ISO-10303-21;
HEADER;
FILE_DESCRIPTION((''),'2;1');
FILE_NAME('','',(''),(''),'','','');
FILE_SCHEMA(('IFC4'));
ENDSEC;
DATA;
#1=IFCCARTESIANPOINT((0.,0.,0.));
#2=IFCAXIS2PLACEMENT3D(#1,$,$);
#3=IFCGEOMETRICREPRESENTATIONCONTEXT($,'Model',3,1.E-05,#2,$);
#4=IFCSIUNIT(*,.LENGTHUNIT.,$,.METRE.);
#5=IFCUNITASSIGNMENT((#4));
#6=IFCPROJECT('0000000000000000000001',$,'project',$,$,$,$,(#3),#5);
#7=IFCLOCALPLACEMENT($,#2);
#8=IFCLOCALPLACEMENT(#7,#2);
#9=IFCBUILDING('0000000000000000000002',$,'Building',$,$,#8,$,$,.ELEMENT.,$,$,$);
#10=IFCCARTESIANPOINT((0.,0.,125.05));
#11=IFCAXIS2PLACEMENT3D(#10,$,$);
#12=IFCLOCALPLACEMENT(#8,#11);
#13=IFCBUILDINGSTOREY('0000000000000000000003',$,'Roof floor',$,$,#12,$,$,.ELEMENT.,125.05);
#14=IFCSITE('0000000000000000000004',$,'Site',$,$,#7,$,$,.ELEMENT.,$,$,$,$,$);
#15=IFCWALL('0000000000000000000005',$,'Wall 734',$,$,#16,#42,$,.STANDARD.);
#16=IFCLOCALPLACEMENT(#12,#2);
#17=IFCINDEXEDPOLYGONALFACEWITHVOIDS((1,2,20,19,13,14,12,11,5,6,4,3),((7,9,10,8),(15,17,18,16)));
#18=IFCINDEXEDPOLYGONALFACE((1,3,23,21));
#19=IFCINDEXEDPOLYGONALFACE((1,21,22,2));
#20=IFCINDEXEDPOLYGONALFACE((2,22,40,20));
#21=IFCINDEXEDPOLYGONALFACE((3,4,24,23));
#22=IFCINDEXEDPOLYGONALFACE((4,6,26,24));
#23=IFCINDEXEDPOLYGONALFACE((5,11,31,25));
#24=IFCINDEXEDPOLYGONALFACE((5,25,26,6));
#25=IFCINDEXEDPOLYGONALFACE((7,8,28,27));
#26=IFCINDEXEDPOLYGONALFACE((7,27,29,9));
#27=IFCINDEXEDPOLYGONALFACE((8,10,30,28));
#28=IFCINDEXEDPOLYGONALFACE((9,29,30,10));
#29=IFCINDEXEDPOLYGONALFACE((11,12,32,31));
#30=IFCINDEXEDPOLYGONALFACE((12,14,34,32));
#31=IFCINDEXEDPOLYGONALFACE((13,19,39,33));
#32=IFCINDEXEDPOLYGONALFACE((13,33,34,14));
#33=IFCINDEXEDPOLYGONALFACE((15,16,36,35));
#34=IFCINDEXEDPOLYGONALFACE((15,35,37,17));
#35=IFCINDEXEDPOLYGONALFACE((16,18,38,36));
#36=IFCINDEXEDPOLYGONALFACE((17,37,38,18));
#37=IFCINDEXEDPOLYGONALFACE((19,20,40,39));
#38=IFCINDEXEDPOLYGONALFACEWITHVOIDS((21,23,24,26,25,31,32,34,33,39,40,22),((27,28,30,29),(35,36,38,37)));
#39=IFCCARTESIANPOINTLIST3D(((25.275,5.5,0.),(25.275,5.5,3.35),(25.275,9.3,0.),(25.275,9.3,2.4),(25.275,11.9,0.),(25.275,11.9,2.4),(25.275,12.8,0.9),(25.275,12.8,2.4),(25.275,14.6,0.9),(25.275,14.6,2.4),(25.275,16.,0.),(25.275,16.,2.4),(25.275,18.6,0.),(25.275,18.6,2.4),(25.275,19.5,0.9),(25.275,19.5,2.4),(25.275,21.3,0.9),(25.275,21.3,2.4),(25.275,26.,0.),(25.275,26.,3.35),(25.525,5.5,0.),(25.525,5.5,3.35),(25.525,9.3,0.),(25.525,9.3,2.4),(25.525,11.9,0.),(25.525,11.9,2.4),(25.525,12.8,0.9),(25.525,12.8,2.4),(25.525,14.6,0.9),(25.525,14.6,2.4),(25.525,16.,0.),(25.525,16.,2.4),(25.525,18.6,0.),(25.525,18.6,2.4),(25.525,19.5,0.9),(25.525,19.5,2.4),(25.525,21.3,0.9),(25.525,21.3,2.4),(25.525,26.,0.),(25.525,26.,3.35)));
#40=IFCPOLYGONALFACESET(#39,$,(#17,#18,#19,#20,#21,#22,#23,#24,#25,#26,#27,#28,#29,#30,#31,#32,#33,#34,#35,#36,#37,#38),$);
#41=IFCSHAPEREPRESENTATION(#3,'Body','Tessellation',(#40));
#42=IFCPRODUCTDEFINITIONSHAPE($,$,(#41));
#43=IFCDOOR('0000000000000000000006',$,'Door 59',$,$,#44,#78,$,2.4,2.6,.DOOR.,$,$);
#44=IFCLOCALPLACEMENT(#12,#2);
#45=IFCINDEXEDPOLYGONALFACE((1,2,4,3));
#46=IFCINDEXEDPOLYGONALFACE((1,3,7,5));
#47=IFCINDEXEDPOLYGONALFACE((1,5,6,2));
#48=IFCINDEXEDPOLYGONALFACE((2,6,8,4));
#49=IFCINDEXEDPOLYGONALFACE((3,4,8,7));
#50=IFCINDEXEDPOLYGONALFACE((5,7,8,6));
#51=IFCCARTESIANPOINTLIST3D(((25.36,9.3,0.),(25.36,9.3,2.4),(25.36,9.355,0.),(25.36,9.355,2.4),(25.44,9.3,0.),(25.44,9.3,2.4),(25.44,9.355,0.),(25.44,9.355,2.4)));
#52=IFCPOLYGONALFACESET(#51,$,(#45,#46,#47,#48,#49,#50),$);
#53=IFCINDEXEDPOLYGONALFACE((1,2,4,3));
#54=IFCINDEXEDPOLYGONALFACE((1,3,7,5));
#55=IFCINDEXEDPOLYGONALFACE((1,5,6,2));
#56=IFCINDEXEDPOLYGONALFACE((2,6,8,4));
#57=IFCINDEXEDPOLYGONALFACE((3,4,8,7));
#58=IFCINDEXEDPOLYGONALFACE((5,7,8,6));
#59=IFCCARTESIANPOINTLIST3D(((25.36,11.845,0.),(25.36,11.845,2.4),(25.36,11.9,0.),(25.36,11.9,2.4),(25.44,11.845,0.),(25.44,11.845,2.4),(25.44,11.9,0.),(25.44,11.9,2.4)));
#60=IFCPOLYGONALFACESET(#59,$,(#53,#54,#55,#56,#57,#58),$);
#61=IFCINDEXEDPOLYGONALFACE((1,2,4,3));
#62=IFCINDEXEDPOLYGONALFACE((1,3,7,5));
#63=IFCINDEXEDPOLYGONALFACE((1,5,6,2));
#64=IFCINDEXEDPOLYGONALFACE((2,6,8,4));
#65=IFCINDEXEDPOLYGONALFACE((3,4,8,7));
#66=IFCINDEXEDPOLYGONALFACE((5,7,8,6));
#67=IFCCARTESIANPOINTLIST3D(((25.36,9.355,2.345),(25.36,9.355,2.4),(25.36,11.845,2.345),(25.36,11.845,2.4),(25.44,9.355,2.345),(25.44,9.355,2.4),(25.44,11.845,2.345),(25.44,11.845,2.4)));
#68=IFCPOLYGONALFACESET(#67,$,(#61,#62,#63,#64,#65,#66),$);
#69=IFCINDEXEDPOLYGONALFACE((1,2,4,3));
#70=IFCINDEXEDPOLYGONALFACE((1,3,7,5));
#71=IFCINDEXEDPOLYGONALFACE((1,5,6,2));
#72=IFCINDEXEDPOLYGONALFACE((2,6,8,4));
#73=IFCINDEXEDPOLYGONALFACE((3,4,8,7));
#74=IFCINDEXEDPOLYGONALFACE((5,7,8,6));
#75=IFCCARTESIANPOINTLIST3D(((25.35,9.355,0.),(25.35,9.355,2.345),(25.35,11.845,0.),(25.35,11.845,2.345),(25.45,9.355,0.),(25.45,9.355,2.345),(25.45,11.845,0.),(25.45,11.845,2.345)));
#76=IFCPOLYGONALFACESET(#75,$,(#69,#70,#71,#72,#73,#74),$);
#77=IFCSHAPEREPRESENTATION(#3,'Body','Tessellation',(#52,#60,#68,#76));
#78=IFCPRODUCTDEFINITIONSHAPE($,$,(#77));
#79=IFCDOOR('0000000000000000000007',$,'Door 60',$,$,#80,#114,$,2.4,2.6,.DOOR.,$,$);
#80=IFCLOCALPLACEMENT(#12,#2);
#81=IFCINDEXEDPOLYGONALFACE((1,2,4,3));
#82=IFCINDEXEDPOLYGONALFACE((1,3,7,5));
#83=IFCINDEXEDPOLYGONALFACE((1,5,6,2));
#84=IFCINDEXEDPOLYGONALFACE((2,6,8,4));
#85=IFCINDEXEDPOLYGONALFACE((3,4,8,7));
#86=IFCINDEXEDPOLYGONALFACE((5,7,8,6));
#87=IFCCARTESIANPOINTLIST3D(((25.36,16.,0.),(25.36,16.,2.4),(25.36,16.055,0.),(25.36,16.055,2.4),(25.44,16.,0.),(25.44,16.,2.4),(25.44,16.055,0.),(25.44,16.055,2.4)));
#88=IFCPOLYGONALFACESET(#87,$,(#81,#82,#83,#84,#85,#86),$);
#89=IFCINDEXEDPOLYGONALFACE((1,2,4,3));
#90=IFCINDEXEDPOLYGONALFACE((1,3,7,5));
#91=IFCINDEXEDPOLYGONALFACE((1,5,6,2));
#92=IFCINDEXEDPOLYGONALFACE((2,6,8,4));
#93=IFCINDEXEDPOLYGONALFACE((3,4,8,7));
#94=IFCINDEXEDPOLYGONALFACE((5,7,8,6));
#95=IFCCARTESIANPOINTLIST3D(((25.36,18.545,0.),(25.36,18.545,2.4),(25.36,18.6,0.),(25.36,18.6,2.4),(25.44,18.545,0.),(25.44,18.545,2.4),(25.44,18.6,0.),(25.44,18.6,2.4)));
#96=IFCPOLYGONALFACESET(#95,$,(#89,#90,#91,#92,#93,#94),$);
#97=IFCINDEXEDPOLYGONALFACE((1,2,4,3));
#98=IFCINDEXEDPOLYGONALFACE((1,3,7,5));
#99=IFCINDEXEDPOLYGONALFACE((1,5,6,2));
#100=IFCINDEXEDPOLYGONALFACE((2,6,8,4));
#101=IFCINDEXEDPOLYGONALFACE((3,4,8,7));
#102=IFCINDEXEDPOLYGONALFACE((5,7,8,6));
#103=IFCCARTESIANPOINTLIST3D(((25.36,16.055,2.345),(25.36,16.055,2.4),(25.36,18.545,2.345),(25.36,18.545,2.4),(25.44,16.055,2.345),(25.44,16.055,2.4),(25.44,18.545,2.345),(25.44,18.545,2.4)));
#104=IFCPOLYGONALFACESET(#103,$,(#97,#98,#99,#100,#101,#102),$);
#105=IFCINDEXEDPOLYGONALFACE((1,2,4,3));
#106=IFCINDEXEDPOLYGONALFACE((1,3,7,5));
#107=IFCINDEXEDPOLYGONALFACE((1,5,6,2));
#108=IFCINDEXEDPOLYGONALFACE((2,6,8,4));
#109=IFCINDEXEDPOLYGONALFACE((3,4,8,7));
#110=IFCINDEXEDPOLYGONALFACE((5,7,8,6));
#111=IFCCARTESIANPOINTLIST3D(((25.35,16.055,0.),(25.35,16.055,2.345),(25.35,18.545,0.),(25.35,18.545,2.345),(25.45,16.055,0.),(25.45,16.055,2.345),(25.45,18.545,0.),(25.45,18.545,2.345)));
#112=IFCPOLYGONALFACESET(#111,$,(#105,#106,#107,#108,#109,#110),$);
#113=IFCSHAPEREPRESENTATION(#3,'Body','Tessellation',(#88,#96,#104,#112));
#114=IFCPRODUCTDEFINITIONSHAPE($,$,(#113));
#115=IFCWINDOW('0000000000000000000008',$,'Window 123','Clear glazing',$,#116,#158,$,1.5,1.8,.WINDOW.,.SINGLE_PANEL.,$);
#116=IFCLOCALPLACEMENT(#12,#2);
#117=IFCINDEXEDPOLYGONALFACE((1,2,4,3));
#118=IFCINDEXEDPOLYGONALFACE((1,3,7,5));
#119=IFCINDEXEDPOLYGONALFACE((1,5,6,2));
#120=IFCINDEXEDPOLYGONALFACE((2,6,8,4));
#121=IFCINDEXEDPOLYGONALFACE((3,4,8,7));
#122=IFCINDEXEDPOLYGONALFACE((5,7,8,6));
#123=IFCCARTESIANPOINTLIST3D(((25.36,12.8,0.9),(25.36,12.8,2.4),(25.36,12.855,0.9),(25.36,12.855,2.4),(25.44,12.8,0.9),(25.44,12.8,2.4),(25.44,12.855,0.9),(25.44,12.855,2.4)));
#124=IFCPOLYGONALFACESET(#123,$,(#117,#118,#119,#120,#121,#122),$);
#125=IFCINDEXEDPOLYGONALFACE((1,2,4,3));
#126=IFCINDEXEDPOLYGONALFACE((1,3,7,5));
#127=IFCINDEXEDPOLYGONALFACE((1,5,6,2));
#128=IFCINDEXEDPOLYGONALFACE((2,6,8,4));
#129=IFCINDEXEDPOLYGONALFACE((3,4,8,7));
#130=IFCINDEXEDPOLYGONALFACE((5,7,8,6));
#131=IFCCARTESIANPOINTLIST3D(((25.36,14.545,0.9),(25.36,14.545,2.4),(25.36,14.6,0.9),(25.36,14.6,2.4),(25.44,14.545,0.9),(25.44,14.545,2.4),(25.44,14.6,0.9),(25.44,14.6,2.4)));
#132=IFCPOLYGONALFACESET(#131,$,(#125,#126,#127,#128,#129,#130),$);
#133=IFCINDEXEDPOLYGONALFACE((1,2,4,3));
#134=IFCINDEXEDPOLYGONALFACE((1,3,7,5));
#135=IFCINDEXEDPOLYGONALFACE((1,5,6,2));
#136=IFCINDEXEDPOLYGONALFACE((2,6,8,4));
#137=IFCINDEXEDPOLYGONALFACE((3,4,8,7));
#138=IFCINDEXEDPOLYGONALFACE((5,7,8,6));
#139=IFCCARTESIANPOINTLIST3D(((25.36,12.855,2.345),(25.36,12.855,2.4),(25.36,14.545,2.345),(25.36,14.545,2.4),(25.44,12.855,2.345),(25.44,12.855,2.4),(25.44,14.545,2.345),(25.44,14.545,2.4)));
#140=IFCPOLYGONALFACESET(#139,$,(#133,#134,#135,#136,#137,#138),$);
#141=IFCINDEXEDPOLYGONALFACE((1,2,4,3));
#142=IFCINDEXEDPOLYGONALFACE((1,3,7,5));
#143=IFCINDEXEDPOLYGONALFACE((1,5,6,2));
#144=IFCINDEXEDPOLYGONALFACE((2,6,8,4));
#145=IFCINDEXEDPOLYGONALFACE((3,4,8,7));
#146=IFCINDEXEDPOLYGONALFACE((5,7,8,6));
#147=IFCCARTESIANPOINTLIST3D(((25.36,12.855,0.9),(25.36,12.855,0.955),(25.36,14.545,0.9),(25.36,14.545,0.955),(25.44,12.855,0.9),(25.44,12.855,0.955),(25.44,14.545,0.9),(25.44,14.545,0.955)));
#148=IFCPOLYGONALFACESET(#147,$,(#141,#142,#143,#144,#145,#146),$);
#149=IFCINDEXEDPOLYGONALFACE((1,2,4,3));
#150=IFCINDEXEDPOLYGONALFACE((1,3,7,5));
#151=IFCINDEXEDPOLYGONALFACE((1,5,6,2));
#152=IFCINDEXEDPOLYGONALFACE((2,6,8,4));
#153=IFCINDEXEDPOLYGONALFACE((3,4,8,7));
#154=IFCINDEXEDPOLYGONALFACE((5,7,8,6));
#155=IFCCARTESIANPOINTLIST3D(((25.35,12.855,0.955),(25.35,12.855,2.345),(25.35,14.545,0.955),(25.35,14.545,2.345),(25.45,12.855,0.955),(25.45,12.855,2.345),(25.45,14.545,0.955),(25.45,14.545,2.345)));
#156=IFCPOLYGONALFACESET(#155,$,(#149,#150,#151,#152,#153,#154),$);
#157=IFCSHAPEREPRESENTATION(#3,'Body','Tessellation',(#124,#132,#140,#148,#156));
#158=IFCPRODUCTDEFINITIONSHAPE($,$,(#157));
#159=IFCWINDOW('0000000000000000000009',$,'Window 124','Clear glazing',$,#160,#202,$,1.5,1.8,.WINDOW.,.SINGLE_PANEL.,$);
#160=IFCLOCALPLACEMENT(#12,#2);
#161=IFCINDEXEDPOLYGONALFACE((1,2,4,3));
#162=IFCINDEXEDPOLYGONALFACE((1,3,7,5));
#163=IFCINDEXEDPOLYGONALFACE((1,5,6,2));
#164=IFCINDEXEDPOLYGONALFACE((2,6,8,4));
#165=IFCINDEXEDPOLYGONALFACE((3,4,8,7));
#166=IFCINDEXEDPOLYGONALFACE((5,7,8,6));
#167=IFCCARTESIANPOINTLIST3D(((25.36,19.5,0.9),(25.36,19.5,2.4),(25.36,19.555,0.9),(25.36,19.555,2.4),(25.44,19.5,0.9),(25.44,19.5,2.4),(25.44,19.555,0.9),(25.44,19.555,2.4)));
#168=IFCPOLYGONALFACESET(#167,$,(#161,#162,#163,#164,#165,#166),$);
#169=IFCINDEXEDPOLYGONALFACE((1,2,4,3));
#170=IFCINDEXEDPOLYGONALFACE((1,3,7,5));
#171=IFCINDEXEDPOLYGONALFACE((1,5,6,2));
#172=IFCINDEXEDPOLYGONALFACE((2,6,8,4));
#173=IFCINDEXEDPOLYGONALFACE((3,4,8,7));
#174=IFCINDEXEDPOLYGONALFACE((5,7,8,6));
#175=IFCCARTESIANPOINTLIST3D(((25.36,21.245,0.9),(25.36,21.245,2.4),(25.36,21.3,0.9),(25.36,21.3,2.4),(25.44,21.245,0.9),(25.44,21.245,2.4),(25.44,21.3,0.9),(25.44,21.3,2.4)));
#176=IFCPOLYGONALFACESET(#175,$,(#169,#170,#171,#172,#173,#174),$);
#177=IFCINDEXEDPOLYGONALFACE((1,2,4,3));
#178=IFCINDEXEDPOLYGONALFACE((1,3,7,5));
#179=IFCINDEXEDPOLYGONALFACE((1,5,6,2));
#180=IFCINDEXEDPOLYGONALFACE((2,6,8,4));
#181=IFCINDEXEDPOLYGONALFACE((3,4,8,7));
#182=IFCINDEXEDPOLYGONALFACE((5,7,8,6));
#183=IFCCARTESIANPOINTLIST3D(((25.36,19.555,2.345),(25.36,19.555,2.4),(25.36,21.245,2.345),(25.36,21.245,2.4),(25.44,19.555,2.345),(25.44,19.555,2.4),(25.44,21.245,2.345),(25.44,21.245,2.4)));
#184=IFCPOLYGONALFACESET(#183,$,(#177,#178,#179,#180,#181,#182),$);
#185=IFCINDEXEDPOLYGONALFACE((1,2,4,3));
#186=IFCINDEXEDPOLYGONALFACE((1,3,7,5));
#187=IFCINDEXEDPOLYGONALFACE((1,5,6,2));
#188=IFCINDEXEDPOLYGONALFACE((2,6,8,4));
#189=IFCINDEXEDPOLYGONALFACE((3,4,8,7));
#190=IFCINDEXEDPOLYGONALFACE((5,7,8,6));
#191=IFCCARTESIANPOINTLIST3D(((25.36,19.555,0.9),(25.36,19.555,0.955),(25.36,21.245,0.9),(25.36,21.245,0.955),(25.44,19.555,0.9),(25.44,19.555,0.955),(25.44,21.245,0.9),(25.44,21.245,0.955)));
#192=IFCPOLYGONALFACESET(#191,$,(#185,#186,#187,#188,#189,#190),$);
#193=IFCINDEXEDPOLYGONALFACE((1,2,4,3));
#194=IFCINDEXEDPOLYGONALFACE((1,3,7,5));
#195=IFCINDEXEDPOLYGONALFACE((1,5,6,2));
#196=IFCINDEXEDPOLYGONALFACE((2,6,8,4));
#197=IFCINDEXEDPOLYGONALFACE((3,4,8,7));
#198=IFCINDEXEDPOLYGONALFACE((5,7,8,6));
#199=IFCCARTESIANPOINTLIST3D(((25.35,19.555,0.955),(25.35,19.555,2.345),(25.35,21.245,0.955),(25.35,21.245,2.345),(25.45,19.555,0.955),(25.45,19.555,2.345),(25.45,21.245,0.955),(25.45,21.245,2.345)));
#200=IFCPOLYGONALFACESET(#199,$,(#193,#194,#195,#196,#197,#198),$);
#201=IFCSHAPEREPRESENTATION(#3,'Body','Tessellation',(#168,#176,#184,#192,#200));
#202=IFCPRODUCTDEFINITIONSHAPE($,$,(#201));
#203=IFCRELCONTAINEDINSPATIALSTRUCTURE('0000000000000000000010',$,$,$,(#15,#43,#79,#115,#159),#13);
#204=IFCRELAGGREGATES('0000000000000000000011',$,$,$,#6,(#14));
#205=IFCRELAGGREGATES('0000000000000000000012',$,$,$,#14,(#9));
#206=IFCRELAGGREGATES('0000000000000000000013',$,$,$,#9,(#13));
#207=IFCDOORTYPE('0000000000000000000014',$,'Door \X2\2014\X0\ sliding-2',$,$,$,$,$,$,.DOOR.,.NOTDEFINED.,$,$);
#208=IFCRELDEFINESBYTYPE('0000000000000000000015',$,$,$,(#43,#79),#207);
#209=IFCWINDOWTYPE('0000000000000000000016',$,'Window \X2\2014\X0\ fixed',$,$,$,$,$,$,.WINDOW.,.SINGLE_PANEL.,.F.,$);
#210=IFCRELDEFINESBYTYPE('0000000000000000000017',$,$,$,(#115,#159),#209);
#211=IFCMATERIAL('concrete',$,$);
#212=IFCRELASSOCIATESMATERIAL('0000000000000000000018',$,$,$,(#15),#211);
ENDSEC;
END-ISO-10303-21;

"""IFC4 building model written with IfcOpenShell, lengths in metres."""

from ifc_helpers import new_model, si_unit, frame, frame_2d, origin, place, context, project, spatial, rectangle, extrude, material, type_object, element, fill, save


model = new_model("IFC4")

# Units and contexts
model_context = context("Model", 3, precision=1e-05, world=origin())
ifc_project = project(units=[si_unit("LENGTHUNIT", "METRE")], contexts=[model_context])

# Site, building, storey
site_placement = place(None, origin())
site = spatial("IfcSite", under=ifc_project, at=site_placement, Name="Site", CompositionType="ELEMENT")
building_placement = place(site_placement, origin())
building = spatial("IfcBuilding", under=site, at=building_placement, Name="Building", CompositionType="ELEMENT")
storey_placement = place(building_placement, frame((0.0, 0.0, 125.05)))
storey = spatial("IfcBuildingStorey", under=building, at=storey_placement, Name="Roof floor", CompositionType="ELEMENT", Elevation=125.05)

# Shared definitions
ifc_material = material(Name="concrete")

# Shared definitions
door_type = type_object("IfcDoorType", Name="Door — sliding-2", PredefinedType="DOOR")
window_type = type_object("IfcWindowType", Name="Window — fixed", ParameterTakesPrecedence=False, PartitioningType="SINGLE_PANEL", PredefinedType="WINDOW")

# Wall, openings, doors, windows
wall_1_placement = place(storey_placement, frame((25.4, 5.5, 0.0), z_axis=(0.0, 0.0, 1.0), x_axis=(0.0, 1.0, 0.0)))
wall_1 = element("IfcWall", 1, at=wall_1_placement, inside=storey, material=ifc_material, Name="Wall 734", PredefinedType="STANDARD", context=model_context, shape_type="SweptSolid", body=[
    extrude(rectangle(XDim=20.5, YDim=0.25, at=frame_2d((10.25, 0.0))), origin(), (0.0, 0.0, 1.0), 3.35),
])
opening_1_placement = place(storey_placement, frame((25.4, 9.3, 0.0), z_axis=(0.0, 0.0, 1.0), x_axis=(0.0, 1.0, 0.0)))
opening_1 = element("IfcOpeningElement", 2, at=opening_1_placement, cuts=wall_1, PredefinedType="OPENING", context=model_context, shape_type="SweptSolid", body=[
    extrude(rectangle(XDim=2.6, YDim=0.31, at=frame_2d((1.3, 0.0))), origin(), (0.0, 0.0, 1.0), 2.4),
])
opening_2_placement = place(storey_placement, frame((25.4, 12.8, 0.9), z_axis=(0.0, 0.0, 1.0), x_axis=(0.0, 1.0, 0.0)))
opening_2 = element("IfcOpeningElement", 3, at=opening_2_placement, cuts=wall_1, PredefinedType="OPENING", context=model_context, shape_type="SweptSolid", body=[
    extrude(rectangle(XDim=1.8, YDim=0.31, at=frame_2d((0.9, 0.0))), origin(), (0.0, 0.0, 1.0), 1.5),
])
opening_3_placement = place(storey_placement, frame((25.4, 16.0, 0.0), z_axis=(0.0, 0.0, 1.0), x_axis=(0.0, 1.0, 0.0)))
opening_3 = element("IfcOpeningElement", 4, at=opening_3_placement, cuts=wall_1, PredefinedType="OPENING", context=model_context, shape_type="SweptSolid", body=[
    extrude(rectangle(XDim=2.6, YDim=0.31, at=frame_2d((1.3, 0.0))), origin(), (0.0, 0.0, 1.0), 2.4),
])
opening_4_placement = place(storey_placement, frame((25.4, 19.5, 0.9), z_axis=(0.0, 0.0, 1.0), x_axis=(0.0, 1.0, 0.0)))
opening_4 = element("IfcOpeningElement", 5, at=opening_4_placement, cuts=wall_1, PredefinedType="OPENING", context=model_context, shape_type="SweptSolid", body=[
    extrude(rectangle(XDim=1.8, YDim=0.31, at=frame_2d((0.9, 0.0))), origin(), (0.0, 0.0, 1.0), 1.5),
])
door_1_placement = place(storey_placement, frame((25.4, 9.3, 0.0), z_axis=(0.0, 0.0, 1.0), x_axis=(0.0, 1.0, 0.0)))
door_1 = element("IfcDoor", 6, at=door_1_placement, inside=storey, type_object=door_type, Name="Door 59", OverallHeight=2.4, OverallWidth=2.6, PredefinedType="DOOR", context=model_context, shape_type="SweptSolid", body=[
    extrude(rectangle(XDim=0.055, YDim=0.08, at=frame_2d((0.0275, 0.0))), origin(), (0.0, 0.0, 1.0), 2.4),
    extrude(rectangle(XDim=0.055, YDim=0.08, at=frame_2d((2.5725, 0.0))), origin(), (0.0, 0.0, 1.0), 2.4),
    extrude(rectangle(XDim=2.49, YDim=0.08, at=frame_2d((1.3, 0.0))), frame((0.0, 0.0, 2.345)), (0.0, 0.0, 1.0), 0.055),
    extrude(rectangle(XDim=2.49, YDim=0.1, at=frame_2d((1.3, 0.0))), origin(), (0.0, 0.0, 1.0), 2.345),
])
fill(opening_1, door_1)
door_2_placement = place(storey_placement, frame((25.4, 16.0, 0.0), z_axis=(0.0, 0.0, 1.0), x_axis=(0.0, 1.0, 0.0)))
door_2 = element("IfcDoor", 7, at=door_2_placement, inside=storey, type_object=door_type, Name="Door 60", OverallHeight=2.4, OverallWidth=2.6, PredefinedType="DOOR", context=model_context, shape_type="SweptSolid", body=[
    extrude(rectangle(XDim=0.055, YDim=0.08, at=frame_2d((0.0275, 0.0))), origin(), (0.0, 0.0, 1.0), 2.4),
    extrude(rectangle(XDim=0.055, YDim=0.08, at=frame_2d((2.5725, 0.0))), origin(), (0.0, 0.0, 1.0), 2.4),
    extrude(rectangle(XDim=2.49, YDim=0.08, at=frame_2d((1.3, 0.0))), frame((0.0, 0.0, 2.345)), (0.0, 0.0, 1.0), 0.055),
    extrude(rectangle(XDim=2.49, YDim=0.1, at=frame_2d((1.3, 0.0))), origin(), (0.0, 0.0, 1.0), 2.345),
])
fill(opening_3, door_2)
window_1_placement = place(storey_placement, frame((25.4, 12.8, 0.9), z_axis=(0.0, 0.0, 1.0), x_axis=(0.0, 1.0, 0.0)))
window_1 = element("IfcWindow", 8, at=window_1_placement, inside=storey, type_object=window_type, Name="Window 123", Description="Clear glazing", OverallHeight=1.5, OverallWidth=1.8, PartitioningType="SINGLE_PANEL", PredefinedType="WINDOW", context=model_context, shape_type="SweptSolid", body=[
    extrude(rectangle(XDim=0.055, YDim=0.08, at=frame_2d((0.0275, 0.0))), origin(), (0.0, 0.0, 1.0), 1.5),
    extrude(rectangle(XDim=0.055, YDim=0.08, at=frame_2d((1.7725, 0.0))), origin(), (0.0, 0.0, 1.0), 1.5),
    extrude(rectangle(XDim=1.69, YDim=0.08, at=frame_2d((0.9, 0.0))), frame((0.0, 0.0, 1.445)), (0.0, 0.0, 1.0), 0.055),
    extrude(rectangle(XDim=1.69, YDim=0.08, at=frame_2d((0.9, 0.0))), origin(), (0.0, 0.0, 1.0), 0.055),
    extrude(rectangle(XDim=1.69, YDim=0.1, at=frame_2d((0.9, 0.0))), frame((0.0, 0.0, 0.055)), (0.0, 0.0, 1.0), 1.39),
])
fill(opening_2, window_1)
window_2_placement = place(storey_placement, frame((25.4, 19.5, 0.9), z_axis=(0.0, 0.0, 1.0), x_axis=(0.0, 1.0, 0.0)))
window_2 = element("IfcWindow", 9, at=window_2_placement, inside=storey, type_object=window_type, Name="Window 124", Description="Clear glazing", OverallHeight=1.5, OverallWidth=1.8, PartitioningType="SINGLE_PANEL", PredefinedType="WINDOW", context=model_context, shape_type="SweptSolid", body=[
    extrude(rectangle(XDim=0.055, YDim=0.08, at=frame_2d((0.0275, 0.0))), origin(), (0.0, 0.0, 1.0), 1.5),
    extrude(rectangle(XDim=0.055, YDim=0.08, at=frame_2d((1.7725, 0.0))), origin(), (0.0, 0.0, 1.0), 1.5),
    extrude(rectangle(XDim=1.69, YDim=0.08, at=frame_2d((0.9, 0.0))), frame((0.0, 0.0, 1.445)), (0.0, 0.0, 1.0), 0.055),
    extrude(rectangle(XDim=1.69, YDim=0.08, at=frame_2d((0.9, 0.0))), origin(), (0.0, 0.0, 1.0), 0.055),
    extrude(rectangle(XDim=1.69, YDim=0.1, at=frame_2d((0.9, 0.0))), frame((0.0, 0.0, 0.055)), (0.0, 0.0, 1.0), 1.39),
])
fill(opening_4, window_2)

save(model, "model.ifc")
